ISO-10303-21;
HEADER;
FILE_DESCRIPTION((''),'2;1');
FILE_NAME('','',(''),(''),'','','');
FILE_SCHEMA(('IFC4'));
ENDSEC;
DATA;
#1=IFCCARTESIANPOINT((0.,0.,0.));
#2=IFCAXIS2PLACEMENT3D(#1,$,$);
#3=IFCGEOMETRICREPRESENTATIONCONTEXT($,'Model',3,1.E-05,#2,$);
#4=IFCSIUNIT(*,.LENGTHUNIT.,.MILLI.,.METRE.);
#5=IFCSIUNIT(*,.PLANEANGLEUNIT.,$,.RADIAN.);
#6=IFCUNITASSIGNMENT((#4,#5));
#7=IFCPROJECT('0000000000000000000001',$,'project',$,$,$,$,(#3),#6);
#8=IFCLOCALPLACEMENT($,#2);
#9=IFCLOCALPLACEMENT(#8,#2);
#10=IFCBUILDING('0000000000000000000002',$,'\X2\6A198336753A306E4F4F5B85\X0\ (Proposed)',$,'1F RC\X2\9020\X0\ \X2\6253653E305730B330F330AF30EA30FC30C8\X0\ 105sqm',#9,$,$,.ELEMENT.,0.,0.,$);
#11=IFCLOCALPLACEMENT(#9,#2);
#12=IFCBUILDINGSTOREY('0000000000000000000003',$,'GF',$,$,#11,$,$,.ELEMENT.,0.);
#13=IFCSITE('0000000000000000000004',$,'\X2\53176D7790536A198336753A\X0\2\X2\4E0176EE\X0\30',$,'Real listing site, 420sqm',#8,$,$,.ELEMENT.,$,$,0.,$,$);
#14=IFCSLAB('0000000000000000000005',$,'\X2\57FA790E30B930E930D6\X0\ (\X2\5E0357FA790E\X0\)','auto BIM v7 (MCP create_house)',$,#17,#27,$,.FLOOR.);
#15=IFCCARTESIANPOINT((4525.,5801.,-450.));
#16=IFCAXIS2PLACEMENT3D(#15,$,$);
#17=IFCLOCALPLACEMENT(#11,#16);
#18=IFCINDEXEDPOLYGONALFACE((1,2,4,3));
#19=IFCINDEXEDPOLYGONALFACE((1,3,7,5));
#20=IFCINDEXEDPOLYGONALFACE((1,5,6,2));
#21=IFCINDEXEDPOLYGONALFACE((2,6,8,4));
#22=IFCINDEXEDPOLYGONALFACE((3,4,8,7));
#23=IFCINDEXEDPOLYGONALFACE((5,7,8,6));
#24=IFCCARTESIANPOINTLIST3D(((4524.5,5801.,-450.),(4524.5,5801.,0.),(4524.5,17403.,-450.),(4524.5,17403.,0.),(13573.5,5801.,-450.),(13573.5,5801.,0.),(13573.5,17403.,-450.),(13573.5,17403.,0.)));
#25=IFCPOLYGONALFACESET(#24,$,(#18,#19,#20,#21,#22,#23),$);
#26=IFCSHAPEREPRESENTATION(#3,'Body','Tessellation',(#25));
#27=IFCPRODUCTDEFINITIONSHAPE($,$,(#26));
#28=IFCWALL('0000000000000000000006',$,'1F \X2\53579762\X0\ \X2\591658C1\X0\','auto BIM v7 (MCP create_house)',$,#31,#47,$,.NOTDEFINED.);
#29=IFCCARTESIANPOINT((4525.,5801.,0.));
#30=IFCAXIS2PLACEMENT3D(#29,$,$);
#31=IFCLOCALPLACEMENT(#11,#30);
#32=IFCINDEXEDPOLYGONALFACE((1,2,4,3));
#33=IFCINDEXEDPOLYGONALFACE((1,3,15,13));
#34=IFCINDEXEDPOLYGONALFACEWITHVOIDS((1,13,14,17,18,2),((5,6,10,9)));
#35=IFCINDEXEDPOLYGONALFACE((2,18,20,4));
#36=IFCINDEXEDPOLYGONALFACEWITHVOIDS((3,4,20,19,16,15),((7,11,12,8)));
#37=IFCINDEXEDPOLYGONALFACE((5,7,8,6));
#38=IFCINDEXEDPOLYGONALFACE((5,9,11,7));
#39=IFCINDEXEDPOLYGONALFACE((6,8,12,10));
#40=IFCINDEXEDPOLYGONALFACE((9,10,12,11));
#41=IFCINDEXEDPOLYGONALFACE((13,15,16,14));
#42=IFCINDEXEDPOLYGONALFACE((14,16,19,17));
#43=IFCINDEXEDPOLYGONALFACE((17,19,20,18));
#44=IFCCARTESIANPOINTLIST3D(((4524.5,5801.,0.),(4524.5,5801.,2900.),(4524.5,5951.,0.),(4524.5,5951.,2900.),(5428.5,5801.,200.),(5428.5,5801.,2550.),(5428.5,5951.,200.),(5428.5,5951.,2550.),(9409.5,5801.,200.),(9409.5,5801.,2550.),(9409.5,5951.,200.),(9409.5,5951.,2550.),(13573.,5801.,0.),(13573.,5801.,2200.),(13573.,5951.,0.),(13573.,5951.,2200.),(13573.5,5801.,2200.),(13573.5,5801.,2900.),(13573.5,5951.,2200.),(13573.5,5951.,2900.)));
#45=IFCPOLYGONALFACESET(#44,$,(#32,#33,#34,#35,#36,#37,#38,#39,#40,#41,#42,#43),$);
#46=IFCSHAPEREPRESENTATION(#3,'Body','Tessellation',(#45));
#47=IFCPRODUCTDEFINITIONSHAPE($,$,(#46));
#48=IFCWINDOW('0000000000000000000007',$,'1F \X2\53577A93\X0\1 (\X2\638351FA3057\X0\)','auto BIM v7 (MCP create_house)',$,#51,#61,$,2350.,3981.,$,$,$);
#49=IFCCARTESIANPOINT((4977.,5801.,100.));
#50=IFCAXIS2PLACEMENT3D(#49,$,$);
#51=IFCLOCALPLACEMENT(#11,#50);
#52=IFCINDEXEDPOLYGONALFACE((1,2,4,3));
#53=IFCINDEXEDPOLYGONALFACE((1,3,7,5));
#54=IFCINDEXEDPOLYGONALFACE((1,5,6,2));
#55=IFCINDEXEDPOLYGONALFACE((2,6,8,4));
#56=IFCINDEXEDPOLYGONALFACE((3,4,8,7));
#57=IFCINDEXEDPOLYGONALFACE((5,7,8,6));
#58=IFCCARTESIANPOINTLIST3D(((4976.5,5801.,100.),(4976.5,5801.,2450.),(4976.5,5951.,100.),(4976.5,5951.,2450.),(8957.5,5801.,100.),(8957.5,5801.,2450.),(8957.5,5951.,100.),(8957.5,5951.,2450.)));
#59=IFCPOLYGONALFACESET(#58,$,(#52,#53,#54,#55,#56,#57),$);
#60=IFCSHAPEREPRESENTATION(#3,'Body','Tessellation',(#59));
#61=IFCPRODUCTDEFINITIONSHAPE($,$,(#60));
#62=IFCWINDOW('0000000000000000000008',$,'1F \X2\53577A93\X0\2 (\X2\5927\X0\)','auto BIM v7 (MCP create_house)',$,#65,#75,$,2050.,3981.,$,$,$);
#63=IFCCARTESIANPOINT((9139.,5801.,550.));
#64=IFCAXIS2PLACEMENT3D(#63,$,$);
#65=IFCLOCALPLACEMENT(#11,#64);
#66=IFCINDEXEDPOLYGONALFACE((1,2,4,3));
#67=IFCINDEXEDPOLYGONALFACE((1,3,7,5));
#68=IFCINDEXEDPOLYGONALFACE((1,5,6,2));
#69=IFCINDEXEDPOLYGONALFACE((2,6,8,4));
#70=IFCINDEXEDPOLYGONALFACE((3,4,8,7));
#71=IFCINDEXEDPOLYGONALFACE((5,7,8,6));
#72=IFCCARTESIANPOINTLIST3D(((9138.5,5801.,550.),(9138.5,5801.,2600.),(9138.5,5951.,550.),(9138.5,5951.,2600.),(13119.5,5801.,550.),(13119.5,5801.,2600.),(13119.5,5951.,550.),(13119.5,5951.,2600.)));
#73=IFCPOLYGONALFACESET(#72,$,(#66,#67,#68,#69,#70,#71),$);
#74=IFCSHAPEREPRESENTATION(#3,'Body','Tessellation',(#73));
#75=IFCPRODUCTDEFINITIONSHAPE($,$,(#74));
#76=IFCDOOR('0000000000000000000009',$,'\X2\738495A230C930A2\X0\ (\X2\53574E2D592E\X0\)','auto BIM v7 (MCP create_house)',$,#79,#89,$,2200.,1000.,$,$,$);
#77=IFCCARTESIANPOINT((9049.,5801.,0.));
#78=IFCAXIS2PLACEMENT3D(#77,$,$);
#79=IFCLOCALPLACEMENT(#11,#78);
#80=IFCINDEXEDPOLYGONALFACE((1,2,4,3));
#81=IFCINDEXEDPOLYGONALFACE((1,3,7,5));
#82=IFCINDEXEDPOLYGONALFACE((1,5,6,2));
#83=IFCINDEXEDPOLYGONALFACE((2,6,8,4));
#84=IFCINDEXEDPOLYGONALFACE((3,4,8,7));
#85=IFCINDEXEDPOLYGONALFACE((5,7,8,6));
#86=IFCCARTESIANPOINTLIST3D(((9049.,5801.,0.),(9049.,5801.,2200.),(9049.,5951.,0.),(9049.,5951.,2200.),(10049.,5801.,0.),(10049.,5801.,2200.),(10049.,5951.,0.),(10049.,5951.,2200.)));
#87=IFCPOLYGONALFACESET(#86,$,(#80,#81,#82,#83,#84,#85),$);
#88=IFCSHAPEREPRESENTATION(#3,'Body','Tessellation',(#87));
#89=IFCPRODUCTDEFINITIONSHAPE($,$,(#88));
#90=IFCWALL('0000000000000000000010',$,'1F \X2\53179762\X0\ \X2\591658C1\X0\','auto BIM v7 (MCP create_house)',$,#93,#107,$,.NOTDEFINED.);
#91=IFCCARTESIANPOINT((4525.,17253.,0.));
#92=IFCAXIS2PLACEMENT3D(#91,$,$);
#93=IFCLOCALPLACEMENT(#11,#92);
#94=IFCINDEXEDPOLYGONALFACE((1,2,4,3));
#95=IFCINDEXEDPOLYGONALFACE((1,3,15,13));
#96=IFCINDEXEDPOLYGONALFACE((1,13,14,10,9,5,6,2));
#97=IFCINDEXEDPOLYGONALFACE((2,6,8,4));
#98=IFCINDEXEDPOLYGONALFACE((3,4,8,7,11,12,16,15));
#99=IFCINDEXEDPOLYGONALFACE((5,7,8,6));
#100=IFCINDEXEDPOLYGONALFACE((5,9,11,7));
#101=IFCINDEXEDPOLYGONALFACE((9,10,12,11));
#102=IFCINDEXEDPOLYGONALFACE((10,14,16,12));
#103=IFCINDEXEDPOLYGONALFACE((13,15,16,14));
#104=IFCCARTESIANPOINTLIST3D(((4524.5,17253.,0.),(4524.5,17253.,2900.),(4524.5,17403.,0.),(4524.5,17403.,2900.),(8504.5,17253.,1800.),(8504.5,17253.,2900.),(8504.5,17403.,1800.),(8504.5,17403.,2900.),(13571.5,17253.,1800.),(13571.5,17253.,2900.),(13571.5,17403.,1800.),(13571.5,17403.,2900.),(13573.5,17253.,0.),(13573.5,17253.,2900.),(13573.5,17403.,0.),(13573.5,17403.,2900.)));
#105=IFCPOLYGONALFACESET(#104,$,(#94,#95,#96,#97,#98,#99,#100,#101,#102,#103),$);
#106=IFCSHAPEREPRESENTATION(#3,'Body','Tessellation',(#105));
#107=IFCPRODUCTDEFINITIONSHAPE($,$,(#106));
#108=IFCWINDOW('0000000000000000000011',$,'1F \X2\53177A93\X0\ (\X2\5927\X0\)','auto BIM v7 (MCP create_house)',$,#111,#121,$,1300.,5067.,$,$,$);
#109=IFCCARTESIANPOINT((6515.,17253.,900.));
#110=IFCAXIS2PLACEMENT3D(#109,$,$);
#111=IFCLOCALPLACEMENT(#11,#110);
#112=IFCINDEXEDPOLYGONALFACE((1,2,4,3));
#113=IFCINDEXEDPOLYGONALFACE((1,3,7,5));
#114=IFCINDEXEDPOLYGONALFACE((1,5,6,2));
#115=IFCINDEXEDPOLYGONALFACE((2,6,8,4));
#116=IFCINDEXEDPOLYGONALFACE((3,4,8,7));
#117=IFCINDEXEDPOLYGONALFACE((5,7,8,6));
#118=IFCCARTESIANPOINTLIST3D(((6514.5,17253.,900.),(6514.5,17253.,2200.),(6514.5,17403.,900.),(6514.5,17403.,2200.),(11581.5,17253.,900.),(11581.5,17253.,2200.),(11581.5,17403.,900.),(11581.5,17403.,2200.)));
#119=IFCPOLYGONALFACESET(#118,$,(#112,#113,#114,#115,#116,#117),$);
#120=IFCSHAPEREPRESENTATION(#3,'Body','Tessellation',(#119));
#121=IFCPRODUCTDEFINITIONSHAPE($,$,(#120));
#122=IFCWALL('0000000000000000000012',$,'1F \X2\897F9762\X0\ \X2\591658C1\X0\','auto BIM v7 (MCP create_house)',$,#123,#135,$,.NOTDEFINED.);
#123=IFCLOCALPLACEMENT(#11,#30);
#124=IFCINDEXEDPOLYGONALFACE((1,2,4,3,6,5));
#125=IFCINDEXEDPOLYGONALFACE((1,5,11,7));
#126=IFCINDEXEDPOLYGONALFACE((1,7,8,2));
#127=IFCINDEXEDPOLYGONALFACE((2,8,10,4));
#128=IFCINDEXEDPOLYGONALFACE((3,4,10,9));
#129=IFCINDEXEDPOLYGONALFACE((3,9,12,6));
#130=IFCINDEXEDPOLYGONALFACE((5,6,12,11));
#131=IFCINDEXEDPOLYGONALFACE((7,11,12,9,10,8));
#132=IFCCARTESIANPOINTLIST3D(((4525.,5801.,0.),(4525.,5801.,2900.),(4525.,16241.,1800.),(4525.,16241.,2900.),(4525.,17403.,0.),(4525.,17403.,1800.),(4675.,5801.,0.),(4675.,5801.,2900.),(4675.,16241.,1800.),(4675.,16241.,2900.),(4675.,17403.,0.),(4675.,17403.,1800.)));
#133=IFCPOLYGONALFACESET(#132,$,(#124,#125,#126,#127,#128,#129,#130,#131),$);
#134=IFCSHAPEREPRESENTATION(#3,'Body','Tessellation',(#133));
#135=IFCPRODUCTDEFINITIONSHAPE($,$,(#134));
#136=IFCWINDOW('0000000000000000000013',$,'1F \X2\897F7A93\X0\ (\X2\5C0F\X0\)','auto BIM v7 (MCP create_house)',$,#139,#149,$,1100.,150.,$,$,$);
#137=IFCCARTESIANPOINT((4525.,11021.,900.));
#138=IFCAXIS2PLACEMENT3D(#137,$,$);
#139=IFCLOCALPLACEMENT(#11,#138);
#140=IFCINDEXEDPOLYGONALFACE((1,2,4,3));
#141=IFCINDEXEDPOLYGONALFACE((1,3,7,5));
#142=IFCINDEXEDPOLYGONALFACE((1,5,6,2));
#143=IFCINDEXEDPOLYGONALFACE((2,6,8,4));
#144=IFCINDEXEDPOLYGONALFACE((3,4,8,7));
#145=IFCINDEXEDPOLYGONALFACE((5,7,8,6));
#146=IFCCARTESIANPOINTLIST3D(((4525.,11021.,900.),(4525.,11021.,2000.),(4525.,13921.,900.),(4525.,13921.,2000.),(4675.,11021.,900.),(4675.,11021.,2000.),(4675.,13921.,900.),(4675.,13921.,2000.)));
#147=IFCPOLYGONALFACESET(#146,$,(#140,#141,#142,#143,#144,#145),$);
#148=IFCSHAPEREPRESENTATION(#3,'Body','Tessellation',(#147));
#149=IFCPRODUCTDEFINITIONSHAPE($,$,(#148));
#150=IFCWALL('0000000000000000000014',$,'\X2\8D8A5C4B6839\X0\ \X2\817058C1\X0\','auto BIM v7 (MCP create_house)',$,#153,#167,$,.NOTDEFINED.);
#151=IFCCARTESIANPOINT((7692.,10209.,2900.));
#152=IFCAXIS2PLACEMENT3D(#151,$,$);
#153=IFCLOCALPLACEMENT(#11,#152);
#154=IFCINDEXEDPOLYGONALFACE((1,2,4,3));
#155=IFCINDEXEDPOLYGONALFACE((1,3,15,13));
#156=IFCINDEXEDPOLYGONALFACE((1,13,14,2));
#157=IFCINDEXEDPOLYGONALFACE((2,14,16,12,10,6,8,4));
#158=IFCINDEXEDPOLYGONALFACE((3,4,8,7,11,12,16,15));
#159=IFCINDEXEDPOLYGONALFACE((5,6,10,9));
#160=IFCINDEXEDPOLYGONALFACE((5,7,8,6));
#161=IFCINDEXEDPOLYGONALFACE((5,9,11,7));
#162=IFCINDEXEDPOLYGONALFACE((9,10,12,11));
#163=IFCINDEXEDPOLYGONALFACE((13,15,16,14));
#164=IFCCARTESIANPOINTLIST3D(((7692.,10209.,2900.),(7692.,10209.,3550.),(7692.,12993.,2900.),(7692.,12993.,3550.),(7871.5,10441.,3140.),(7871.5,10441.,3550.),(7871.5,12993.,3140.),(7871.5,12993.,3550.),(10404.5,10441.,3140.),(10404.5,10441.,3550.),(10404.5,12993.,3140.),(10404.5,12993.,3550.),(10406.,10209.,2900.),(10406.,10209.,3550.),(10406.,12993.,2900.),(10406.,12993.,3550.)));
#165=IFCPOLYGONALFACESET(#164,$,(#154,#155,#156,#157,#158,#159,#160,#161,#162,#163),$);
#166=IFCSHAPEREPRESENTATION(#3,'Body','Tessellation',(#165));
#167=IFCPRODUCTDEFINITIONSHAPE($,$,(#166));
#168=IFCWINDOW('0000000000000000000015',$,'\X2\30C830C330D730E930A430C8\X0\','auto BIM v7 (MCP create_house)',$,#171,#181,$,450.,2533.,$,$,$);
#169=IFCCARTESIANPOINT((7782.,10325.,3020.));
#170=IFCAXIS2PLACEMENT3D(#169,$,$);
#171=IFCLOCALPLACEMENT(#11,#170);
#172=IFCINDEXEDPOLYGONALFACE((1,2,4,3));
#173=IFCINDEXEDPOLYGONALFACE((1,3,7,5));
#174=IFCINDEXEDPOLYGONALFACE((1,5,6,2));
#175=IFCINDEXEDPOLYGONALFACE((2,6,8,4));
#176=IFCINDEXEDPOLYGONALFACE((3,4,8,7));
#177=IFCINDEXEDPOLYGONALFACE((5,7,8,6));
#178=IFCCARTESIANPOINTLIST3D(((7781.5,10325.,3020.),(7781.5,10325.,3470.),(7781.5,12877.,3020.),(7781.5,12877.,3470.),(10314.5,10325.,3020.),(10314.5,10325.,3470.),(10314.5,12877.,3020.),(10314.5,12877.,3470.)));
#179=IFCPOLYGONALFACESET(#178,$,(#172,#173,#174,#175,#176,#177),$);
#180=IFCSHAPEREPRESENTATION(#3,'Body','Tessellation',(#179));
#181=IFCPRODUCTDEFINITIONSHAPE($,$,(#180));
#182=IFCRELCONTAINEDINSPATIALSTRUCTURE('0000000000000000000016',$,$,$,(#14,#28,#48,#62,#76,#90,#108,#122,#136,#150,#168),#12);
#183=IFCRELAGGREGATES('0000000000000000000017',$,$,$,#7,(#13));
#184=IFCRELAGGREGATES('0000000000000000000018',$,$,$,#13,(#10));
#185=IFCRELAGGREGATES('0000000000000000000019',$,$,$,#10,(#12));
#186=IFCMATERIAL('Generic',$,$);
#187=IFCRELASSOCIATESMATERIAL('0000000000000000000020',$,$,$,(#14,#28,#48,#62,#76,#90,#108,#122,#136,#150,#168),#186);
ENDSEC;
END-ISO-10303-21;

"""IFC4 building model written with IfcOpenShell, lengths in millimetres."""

from ifc_helpers import new_model, si_unit, frame, frame_2d, origin, place, context, project, spatial, rectangle, extrude, material, element, fill, save


model = new_model("IFC4")

# Units and contexts
model_context = context("Model", 3, precision=1e-05, world=origin())
ifc_project = project(units=[si_unit("LENGTHUNIT", "METRE", prefix="MILLI"), si_unit("PLANEANGLEUNIT", "RADIAN")], contexts=[model_context])

# Site, building, storey
site_placement = place(None, origin())
site = spatial("IfcSite", under=ifc_project, at=site_placement, Name="北海道標茶町2丁目30", ObjectType="Real listing site, 420sqm", CompositionType="ELEMENT", RefElevation=0.0)
building_placement = place(site_placement, origin())
building = spatial("IfcBuilding", under=site, at=building_placement, Name="標茶町の住宅 (Proposed)", ObjectType="1F RC造 打放しコンクリート 105sqm", CompositionType="ELEMENT", ElevationOfRefHeight=0.0, ElevationOfTerrain=0.0)
storey_placement = place(building_placement, origin())
storey = spatial("IfcBuildingStorey", under=building, at=storey_placement, Name="GF", CompositionType="ELEMENT", Elevation=0.0)

# Slab
ifc_material = material(Name="Generic")
slab_1_placement = place(storey_placement, frame((4525.0, 5801.0, -450.0)))
element("IfcSlab", 1, at=slab_1_placement, inside=storey, material=ifc_material, Name="基礎スラブ (布基礎)", Description="auto BIM v7 (MCP create_house)", PredefinedType="FLOOR", context=model_context, shape_type="SweptSolid", body=[
    extrude(rectangle(XDim=9049.0, YDim=11602.0, at=frame_2d((4524.0, 5801.0))), frame((4525.0, 5801.0, -450.0)), (0.0, 0.0, 1.0), 450.0),
])

# Wall, openings, windows, door
wall_1_placement = place(storey_placement, frame((4525.0, 5801.0, 0.0)))
wall_1 = element("IfcWall", 2, at=wall_1_placement, inside=storey, material=ifc_material, Name="1F 南面 外壁", Description="auto BIM v7 (MCP create_house)", PredefinedType="NOTDEFINED", context=model_context, shape_type="SweptSolid", body=[
    extrude(rectangle(XDim=9049.0, YDim=150.0, at=frame_2d((4524.0, 75.0))), frame((4525.0, 5801.0, 0.0)), (0.0, 0.0, 1.0), 2900.0),
])
opening_1_placement = place(storey_placement, frame((4977.0, 5801.0, 100.0)))
opening_1 = element("IfcOpeningElement", 3, at=opening_1_placement, cuts=wall_1, PredefinedType="NOTDEFINED", context=model_context, shape_type="SweptSolid", body=[
    extrude(rectangle(XDim=3981.0, YDim=150.0, at=frame_2d((1990.0, 75.0))), frame((4977.0, 5801.0, 100.0)), (0.0, 0.0, 1.0), 2350.0),
])
opening_2_placement = place(storey_placement, frame((9139.0, 5801.0, 550.0)))
opening_2 = element("IfcOpeningElement", 4, at=opening_2_placement, cuts=wall_1, PredefinedType="NOTDEFINED", context=model_context, shape_type="SweptSolid", body=[
    extrude(rectangle(XDim=3981.0, YDim=150.0, at=frame_2d((1990.0, 75.0))), frame((9139.0, 5801.0, 550.0)), (0.0, 0.0, 1.0), 2050.0),
])
opening_3_placement = place(storey_placement, frame((9049.0, 5801.0, 0.0)))
opening_3 = element("IfcOpeningElement", 5, at=opening_3_placement, cuts=wall_1, PredefinedType="NOTDEFINED", context=model_context, shape_type="SweptSolid", body=[
    extrude(rectangle(XDim=1000.0, YDim=150.0, at=frame_2d((500.0, 75.0))), frame((9049.0, 5801.0, 0.0)), (0.0, 0.0, 1.0), 2200.0),
])
window_1_placement = place(storey_placement, frame((4977.0, 5801.0, 100.0)))
window_1 = element("IfcWindow", 6, at=window_1_placement, inside=storey, material=ifc_material, Name="1F 南窓1 (掃出し)", Description="auto BIM v7 (MCP create_house)", OverallHeight=2350.0, OverallWidth=3981.0, context=model_context, shape_type="SweptSolid", body=[
    extrude(rectangle(XDim=3981.0, YDim=150.0, at=frame_2d((1990.0, 75.0))), frame((4977.0, 5801.0, 100.0)), (0.0, 0.0, 1.0), 2350.0),
])
fill(opening_1, window_1)
window_2_placement = place(storey_placement, frame((9139.0, 5801.0, 550.0)))
window_2 = element("IfcWindow", 7, at=window_2_placement, inside=storey, material=ifc_material, Name="1F 南窓2 (大)", Description="auto BIM v7 (MCP create_house)", OverallHeight=2050.0, OverallWidth=3981.0, context=model_context, shape_type="SweptSolid", body=[
    extrude(rectangle(XDim=3981.0, YDim=150.0, at=frame_2d((1990.0, 75.0))), frame((9139.0, 5801.0, 550.0)), (0.0, 0.0, 1.0), 2050.0),
])
fill(opening_2, window_2)
door_placement = place(storey_placement, frame((9049.0, 5801.0, 0.0)))
door = element("IfcDoor", 8, at=door_placement, inside=storey, material=ifc_material, Name="玄関ドア (南中央)", Description="auto BIM v7 (MCP create_house)", OverallHeight=2200.0, OverallWidth=1000.0, context=model_context, shape_type="SweptSolid", body=[
    extrude(rectangle(XDim=1000.0, YDim=150.0, at=frame_2d((500.0, 75.0))), frame((9049.0, 5801.0, 0.0)), (0.0, 0.0, 1.0), 2200.0),
])
fill(opening_3, door)

# Walls, openings, windows
wall_2_placement = place(storey_placement, frame((4525.0, 17253.0, 0.0)))
wall_2 = element("IfcWall", 9, at=wall_2_placement, inside=storey, material=ifc_material, Name="1F 北面 外壁", Description="auto BIM v7 (MCP create_house)", PredefinedType="NOTDEFINED", context=model_context, shape_type="SweptSolid", body=[
    extrude(rectangle(XDim=9049.0, YDim=150.0, at=frame_2d((4524.0, 75.0))), frame((4525.0, 17253.0, 0.0)), (0.0, 0.0, 1.0), 2900.0),
])
opening_4_placement = place(storey_placement, frame((6515.0, 17253.0, 900.0)))
opening_4 = element("IfcOpeningElement", 10, at=opening_4_placement, cuts=wall_2, PredefinedType="NOTDEFINED", context=model_context, shape_type="SweptSolid", body=[
    extrude(rectangle(XDim=5067.0, YDim=150.0, at=frame_2d((2533.0, 75.0))), frame((6515.0, 17253.0, 900.0)), (0.0, 0.0, 1.0), 1300.0),
])
window_3_placement = place(storey_placement, frame((6515.0, 17253.0, 900.0)))
window_3 = element("IfcWindow", 11, at=window_3_placement, inside=storey, material=ifc_material, Name="1F 北窓 (大)", Description="auto BIM v7 (MCP create_house)", OverallHeight=1300.0, OverallWidth=5067.0, context=model_context, shape_type="SweptSolid", body=[
    extrude(rectangle(XDim=5067.0, YDim=150.0, at=frame_2d((2533.0, 75.0))), frame((6515.0, 17253.0, 900.0)), (0.0, 0.0, 1.0), 1300.0),
])
fill(opening_4, window_3)
wall_3_placement = place(storey_placement, frame((4525.0, 5801.0, 0.0)))
wall_3 = element("IfcWall", 12, at=wall_3_placement, inside=storey, material=ifc_material, Name="1F 西面 外壁", Description="auto BIM v7 (MCP create_house)", PredefinedType="NOTDEFINED", context=model_context, shape_type="SweptSolid", body=[
    extrude(rectangle(XDim=150.0, YDim=11602.0, at=frame_2d((75.0, 5801.0))), frame((4525.0, 5801.0, 0.0)), (0.0, 0.0, 1.0), 2900.0),
])
opening_5_placement = place(storey_placement, frame((4525.0, 11021.0, 900.0)))
opening_5 = element("IfcOpeningElement", 13, at=opening_5_placement, cuts=wall_3, PredefinedType="NOTDEFINED", context=model_context, shape_type="SweptSolid", body=[
    extrude(rectangle(XDim=150.0, YDim=2900.0, at=frame_2d((75.0, 1450.0))), frame((4525.0, 11021.0, 900.0)), (0.0, 0.0, 1.0), 1100.0),
])
window_4_placement = place(storey_placement, frame((4525.0, 11021.0, 900.0)))
window_4 = element("IfcWindow", 14, at=window_4_placement, inside=storey, material=ifc_material, Name="1F 西窓 (小)", Description="auto BIM v7 (MCP create_house)", OverallHeight=1100.0, OverallWidth=150.0, context=model_context, shape_type="SweptSolid", body=[
    extrude(rectangle(XDim=150.0, YDim=2900.0, at=frame_2d((75.0, 1450.0))), frame((4525.0, 11021.0, 900.0)), (0.0, 0.0, 1.0), 1100.0),
])
fill(opening_5, window_4)

# Wall, opening, window
wall_4_placement = place(storey_placement, frame((7692.0, 10209.0, 2900.0)))
wall_4 = element("IfcWall", 15, at=wall_4_placement, inside=storey, material=ifc_material, Name="越屋根 腰壁", Description="auto BIM v7 (MCP create_house)", PredefinedType="NOTDEFINED", context=model_context, shape_type="SweptSolid", body=[
    extrude(rectangle(XDim=2714.0, YDim=2784.0, at=frame_2d((1357.0, 1392.0))), frame((7692.0, 10209.0, 2900.0)), (0.0, 0.0, 1.0), 650.0),
])
opening_6_placement = place(storey_placement, frame((7782.0, 10325.0, 3020.0)))
opening_6 = element("IfcOpeningElement", 16, at=opening_6_placement, cuts=wall_4, PredefinedType="NOTDEFINED", context=model_context, shape_type="SweptSolid", body=[
    extrude(rectangle(XDim=2533.0, YDim=2552.0, at=frame_2d((1266.0, 1276.0))), frame((7782.0, 10325.0, 3020.0)), (0.0, 0.0, 1.0), 450.0),
])
window_5_placement = place(storey_placement, frame((7782.0, 10325.0, 3020.0)))
window_5 = element("IfcWindow", 17, at=window_5_placement, inside=storey, material=ifc_material, Name="トップライト", Description="auto BIM v7 (MCP create_house)", OverallHeight=450.0, OverallWidth=2533.0, context=model_context, shape_type="SweptSolid", body=[
    extrude(rectangle(XDim=2533.0, YDim=2552.0, at=frame_2d((1266.0, 1276.0))), frame((7782.0, 10325.0, 3020.0)), (0.0, 0.0, 1.0), 450.0),
])
fill(opening_6, window_5)

save(model, "model.ifc")
